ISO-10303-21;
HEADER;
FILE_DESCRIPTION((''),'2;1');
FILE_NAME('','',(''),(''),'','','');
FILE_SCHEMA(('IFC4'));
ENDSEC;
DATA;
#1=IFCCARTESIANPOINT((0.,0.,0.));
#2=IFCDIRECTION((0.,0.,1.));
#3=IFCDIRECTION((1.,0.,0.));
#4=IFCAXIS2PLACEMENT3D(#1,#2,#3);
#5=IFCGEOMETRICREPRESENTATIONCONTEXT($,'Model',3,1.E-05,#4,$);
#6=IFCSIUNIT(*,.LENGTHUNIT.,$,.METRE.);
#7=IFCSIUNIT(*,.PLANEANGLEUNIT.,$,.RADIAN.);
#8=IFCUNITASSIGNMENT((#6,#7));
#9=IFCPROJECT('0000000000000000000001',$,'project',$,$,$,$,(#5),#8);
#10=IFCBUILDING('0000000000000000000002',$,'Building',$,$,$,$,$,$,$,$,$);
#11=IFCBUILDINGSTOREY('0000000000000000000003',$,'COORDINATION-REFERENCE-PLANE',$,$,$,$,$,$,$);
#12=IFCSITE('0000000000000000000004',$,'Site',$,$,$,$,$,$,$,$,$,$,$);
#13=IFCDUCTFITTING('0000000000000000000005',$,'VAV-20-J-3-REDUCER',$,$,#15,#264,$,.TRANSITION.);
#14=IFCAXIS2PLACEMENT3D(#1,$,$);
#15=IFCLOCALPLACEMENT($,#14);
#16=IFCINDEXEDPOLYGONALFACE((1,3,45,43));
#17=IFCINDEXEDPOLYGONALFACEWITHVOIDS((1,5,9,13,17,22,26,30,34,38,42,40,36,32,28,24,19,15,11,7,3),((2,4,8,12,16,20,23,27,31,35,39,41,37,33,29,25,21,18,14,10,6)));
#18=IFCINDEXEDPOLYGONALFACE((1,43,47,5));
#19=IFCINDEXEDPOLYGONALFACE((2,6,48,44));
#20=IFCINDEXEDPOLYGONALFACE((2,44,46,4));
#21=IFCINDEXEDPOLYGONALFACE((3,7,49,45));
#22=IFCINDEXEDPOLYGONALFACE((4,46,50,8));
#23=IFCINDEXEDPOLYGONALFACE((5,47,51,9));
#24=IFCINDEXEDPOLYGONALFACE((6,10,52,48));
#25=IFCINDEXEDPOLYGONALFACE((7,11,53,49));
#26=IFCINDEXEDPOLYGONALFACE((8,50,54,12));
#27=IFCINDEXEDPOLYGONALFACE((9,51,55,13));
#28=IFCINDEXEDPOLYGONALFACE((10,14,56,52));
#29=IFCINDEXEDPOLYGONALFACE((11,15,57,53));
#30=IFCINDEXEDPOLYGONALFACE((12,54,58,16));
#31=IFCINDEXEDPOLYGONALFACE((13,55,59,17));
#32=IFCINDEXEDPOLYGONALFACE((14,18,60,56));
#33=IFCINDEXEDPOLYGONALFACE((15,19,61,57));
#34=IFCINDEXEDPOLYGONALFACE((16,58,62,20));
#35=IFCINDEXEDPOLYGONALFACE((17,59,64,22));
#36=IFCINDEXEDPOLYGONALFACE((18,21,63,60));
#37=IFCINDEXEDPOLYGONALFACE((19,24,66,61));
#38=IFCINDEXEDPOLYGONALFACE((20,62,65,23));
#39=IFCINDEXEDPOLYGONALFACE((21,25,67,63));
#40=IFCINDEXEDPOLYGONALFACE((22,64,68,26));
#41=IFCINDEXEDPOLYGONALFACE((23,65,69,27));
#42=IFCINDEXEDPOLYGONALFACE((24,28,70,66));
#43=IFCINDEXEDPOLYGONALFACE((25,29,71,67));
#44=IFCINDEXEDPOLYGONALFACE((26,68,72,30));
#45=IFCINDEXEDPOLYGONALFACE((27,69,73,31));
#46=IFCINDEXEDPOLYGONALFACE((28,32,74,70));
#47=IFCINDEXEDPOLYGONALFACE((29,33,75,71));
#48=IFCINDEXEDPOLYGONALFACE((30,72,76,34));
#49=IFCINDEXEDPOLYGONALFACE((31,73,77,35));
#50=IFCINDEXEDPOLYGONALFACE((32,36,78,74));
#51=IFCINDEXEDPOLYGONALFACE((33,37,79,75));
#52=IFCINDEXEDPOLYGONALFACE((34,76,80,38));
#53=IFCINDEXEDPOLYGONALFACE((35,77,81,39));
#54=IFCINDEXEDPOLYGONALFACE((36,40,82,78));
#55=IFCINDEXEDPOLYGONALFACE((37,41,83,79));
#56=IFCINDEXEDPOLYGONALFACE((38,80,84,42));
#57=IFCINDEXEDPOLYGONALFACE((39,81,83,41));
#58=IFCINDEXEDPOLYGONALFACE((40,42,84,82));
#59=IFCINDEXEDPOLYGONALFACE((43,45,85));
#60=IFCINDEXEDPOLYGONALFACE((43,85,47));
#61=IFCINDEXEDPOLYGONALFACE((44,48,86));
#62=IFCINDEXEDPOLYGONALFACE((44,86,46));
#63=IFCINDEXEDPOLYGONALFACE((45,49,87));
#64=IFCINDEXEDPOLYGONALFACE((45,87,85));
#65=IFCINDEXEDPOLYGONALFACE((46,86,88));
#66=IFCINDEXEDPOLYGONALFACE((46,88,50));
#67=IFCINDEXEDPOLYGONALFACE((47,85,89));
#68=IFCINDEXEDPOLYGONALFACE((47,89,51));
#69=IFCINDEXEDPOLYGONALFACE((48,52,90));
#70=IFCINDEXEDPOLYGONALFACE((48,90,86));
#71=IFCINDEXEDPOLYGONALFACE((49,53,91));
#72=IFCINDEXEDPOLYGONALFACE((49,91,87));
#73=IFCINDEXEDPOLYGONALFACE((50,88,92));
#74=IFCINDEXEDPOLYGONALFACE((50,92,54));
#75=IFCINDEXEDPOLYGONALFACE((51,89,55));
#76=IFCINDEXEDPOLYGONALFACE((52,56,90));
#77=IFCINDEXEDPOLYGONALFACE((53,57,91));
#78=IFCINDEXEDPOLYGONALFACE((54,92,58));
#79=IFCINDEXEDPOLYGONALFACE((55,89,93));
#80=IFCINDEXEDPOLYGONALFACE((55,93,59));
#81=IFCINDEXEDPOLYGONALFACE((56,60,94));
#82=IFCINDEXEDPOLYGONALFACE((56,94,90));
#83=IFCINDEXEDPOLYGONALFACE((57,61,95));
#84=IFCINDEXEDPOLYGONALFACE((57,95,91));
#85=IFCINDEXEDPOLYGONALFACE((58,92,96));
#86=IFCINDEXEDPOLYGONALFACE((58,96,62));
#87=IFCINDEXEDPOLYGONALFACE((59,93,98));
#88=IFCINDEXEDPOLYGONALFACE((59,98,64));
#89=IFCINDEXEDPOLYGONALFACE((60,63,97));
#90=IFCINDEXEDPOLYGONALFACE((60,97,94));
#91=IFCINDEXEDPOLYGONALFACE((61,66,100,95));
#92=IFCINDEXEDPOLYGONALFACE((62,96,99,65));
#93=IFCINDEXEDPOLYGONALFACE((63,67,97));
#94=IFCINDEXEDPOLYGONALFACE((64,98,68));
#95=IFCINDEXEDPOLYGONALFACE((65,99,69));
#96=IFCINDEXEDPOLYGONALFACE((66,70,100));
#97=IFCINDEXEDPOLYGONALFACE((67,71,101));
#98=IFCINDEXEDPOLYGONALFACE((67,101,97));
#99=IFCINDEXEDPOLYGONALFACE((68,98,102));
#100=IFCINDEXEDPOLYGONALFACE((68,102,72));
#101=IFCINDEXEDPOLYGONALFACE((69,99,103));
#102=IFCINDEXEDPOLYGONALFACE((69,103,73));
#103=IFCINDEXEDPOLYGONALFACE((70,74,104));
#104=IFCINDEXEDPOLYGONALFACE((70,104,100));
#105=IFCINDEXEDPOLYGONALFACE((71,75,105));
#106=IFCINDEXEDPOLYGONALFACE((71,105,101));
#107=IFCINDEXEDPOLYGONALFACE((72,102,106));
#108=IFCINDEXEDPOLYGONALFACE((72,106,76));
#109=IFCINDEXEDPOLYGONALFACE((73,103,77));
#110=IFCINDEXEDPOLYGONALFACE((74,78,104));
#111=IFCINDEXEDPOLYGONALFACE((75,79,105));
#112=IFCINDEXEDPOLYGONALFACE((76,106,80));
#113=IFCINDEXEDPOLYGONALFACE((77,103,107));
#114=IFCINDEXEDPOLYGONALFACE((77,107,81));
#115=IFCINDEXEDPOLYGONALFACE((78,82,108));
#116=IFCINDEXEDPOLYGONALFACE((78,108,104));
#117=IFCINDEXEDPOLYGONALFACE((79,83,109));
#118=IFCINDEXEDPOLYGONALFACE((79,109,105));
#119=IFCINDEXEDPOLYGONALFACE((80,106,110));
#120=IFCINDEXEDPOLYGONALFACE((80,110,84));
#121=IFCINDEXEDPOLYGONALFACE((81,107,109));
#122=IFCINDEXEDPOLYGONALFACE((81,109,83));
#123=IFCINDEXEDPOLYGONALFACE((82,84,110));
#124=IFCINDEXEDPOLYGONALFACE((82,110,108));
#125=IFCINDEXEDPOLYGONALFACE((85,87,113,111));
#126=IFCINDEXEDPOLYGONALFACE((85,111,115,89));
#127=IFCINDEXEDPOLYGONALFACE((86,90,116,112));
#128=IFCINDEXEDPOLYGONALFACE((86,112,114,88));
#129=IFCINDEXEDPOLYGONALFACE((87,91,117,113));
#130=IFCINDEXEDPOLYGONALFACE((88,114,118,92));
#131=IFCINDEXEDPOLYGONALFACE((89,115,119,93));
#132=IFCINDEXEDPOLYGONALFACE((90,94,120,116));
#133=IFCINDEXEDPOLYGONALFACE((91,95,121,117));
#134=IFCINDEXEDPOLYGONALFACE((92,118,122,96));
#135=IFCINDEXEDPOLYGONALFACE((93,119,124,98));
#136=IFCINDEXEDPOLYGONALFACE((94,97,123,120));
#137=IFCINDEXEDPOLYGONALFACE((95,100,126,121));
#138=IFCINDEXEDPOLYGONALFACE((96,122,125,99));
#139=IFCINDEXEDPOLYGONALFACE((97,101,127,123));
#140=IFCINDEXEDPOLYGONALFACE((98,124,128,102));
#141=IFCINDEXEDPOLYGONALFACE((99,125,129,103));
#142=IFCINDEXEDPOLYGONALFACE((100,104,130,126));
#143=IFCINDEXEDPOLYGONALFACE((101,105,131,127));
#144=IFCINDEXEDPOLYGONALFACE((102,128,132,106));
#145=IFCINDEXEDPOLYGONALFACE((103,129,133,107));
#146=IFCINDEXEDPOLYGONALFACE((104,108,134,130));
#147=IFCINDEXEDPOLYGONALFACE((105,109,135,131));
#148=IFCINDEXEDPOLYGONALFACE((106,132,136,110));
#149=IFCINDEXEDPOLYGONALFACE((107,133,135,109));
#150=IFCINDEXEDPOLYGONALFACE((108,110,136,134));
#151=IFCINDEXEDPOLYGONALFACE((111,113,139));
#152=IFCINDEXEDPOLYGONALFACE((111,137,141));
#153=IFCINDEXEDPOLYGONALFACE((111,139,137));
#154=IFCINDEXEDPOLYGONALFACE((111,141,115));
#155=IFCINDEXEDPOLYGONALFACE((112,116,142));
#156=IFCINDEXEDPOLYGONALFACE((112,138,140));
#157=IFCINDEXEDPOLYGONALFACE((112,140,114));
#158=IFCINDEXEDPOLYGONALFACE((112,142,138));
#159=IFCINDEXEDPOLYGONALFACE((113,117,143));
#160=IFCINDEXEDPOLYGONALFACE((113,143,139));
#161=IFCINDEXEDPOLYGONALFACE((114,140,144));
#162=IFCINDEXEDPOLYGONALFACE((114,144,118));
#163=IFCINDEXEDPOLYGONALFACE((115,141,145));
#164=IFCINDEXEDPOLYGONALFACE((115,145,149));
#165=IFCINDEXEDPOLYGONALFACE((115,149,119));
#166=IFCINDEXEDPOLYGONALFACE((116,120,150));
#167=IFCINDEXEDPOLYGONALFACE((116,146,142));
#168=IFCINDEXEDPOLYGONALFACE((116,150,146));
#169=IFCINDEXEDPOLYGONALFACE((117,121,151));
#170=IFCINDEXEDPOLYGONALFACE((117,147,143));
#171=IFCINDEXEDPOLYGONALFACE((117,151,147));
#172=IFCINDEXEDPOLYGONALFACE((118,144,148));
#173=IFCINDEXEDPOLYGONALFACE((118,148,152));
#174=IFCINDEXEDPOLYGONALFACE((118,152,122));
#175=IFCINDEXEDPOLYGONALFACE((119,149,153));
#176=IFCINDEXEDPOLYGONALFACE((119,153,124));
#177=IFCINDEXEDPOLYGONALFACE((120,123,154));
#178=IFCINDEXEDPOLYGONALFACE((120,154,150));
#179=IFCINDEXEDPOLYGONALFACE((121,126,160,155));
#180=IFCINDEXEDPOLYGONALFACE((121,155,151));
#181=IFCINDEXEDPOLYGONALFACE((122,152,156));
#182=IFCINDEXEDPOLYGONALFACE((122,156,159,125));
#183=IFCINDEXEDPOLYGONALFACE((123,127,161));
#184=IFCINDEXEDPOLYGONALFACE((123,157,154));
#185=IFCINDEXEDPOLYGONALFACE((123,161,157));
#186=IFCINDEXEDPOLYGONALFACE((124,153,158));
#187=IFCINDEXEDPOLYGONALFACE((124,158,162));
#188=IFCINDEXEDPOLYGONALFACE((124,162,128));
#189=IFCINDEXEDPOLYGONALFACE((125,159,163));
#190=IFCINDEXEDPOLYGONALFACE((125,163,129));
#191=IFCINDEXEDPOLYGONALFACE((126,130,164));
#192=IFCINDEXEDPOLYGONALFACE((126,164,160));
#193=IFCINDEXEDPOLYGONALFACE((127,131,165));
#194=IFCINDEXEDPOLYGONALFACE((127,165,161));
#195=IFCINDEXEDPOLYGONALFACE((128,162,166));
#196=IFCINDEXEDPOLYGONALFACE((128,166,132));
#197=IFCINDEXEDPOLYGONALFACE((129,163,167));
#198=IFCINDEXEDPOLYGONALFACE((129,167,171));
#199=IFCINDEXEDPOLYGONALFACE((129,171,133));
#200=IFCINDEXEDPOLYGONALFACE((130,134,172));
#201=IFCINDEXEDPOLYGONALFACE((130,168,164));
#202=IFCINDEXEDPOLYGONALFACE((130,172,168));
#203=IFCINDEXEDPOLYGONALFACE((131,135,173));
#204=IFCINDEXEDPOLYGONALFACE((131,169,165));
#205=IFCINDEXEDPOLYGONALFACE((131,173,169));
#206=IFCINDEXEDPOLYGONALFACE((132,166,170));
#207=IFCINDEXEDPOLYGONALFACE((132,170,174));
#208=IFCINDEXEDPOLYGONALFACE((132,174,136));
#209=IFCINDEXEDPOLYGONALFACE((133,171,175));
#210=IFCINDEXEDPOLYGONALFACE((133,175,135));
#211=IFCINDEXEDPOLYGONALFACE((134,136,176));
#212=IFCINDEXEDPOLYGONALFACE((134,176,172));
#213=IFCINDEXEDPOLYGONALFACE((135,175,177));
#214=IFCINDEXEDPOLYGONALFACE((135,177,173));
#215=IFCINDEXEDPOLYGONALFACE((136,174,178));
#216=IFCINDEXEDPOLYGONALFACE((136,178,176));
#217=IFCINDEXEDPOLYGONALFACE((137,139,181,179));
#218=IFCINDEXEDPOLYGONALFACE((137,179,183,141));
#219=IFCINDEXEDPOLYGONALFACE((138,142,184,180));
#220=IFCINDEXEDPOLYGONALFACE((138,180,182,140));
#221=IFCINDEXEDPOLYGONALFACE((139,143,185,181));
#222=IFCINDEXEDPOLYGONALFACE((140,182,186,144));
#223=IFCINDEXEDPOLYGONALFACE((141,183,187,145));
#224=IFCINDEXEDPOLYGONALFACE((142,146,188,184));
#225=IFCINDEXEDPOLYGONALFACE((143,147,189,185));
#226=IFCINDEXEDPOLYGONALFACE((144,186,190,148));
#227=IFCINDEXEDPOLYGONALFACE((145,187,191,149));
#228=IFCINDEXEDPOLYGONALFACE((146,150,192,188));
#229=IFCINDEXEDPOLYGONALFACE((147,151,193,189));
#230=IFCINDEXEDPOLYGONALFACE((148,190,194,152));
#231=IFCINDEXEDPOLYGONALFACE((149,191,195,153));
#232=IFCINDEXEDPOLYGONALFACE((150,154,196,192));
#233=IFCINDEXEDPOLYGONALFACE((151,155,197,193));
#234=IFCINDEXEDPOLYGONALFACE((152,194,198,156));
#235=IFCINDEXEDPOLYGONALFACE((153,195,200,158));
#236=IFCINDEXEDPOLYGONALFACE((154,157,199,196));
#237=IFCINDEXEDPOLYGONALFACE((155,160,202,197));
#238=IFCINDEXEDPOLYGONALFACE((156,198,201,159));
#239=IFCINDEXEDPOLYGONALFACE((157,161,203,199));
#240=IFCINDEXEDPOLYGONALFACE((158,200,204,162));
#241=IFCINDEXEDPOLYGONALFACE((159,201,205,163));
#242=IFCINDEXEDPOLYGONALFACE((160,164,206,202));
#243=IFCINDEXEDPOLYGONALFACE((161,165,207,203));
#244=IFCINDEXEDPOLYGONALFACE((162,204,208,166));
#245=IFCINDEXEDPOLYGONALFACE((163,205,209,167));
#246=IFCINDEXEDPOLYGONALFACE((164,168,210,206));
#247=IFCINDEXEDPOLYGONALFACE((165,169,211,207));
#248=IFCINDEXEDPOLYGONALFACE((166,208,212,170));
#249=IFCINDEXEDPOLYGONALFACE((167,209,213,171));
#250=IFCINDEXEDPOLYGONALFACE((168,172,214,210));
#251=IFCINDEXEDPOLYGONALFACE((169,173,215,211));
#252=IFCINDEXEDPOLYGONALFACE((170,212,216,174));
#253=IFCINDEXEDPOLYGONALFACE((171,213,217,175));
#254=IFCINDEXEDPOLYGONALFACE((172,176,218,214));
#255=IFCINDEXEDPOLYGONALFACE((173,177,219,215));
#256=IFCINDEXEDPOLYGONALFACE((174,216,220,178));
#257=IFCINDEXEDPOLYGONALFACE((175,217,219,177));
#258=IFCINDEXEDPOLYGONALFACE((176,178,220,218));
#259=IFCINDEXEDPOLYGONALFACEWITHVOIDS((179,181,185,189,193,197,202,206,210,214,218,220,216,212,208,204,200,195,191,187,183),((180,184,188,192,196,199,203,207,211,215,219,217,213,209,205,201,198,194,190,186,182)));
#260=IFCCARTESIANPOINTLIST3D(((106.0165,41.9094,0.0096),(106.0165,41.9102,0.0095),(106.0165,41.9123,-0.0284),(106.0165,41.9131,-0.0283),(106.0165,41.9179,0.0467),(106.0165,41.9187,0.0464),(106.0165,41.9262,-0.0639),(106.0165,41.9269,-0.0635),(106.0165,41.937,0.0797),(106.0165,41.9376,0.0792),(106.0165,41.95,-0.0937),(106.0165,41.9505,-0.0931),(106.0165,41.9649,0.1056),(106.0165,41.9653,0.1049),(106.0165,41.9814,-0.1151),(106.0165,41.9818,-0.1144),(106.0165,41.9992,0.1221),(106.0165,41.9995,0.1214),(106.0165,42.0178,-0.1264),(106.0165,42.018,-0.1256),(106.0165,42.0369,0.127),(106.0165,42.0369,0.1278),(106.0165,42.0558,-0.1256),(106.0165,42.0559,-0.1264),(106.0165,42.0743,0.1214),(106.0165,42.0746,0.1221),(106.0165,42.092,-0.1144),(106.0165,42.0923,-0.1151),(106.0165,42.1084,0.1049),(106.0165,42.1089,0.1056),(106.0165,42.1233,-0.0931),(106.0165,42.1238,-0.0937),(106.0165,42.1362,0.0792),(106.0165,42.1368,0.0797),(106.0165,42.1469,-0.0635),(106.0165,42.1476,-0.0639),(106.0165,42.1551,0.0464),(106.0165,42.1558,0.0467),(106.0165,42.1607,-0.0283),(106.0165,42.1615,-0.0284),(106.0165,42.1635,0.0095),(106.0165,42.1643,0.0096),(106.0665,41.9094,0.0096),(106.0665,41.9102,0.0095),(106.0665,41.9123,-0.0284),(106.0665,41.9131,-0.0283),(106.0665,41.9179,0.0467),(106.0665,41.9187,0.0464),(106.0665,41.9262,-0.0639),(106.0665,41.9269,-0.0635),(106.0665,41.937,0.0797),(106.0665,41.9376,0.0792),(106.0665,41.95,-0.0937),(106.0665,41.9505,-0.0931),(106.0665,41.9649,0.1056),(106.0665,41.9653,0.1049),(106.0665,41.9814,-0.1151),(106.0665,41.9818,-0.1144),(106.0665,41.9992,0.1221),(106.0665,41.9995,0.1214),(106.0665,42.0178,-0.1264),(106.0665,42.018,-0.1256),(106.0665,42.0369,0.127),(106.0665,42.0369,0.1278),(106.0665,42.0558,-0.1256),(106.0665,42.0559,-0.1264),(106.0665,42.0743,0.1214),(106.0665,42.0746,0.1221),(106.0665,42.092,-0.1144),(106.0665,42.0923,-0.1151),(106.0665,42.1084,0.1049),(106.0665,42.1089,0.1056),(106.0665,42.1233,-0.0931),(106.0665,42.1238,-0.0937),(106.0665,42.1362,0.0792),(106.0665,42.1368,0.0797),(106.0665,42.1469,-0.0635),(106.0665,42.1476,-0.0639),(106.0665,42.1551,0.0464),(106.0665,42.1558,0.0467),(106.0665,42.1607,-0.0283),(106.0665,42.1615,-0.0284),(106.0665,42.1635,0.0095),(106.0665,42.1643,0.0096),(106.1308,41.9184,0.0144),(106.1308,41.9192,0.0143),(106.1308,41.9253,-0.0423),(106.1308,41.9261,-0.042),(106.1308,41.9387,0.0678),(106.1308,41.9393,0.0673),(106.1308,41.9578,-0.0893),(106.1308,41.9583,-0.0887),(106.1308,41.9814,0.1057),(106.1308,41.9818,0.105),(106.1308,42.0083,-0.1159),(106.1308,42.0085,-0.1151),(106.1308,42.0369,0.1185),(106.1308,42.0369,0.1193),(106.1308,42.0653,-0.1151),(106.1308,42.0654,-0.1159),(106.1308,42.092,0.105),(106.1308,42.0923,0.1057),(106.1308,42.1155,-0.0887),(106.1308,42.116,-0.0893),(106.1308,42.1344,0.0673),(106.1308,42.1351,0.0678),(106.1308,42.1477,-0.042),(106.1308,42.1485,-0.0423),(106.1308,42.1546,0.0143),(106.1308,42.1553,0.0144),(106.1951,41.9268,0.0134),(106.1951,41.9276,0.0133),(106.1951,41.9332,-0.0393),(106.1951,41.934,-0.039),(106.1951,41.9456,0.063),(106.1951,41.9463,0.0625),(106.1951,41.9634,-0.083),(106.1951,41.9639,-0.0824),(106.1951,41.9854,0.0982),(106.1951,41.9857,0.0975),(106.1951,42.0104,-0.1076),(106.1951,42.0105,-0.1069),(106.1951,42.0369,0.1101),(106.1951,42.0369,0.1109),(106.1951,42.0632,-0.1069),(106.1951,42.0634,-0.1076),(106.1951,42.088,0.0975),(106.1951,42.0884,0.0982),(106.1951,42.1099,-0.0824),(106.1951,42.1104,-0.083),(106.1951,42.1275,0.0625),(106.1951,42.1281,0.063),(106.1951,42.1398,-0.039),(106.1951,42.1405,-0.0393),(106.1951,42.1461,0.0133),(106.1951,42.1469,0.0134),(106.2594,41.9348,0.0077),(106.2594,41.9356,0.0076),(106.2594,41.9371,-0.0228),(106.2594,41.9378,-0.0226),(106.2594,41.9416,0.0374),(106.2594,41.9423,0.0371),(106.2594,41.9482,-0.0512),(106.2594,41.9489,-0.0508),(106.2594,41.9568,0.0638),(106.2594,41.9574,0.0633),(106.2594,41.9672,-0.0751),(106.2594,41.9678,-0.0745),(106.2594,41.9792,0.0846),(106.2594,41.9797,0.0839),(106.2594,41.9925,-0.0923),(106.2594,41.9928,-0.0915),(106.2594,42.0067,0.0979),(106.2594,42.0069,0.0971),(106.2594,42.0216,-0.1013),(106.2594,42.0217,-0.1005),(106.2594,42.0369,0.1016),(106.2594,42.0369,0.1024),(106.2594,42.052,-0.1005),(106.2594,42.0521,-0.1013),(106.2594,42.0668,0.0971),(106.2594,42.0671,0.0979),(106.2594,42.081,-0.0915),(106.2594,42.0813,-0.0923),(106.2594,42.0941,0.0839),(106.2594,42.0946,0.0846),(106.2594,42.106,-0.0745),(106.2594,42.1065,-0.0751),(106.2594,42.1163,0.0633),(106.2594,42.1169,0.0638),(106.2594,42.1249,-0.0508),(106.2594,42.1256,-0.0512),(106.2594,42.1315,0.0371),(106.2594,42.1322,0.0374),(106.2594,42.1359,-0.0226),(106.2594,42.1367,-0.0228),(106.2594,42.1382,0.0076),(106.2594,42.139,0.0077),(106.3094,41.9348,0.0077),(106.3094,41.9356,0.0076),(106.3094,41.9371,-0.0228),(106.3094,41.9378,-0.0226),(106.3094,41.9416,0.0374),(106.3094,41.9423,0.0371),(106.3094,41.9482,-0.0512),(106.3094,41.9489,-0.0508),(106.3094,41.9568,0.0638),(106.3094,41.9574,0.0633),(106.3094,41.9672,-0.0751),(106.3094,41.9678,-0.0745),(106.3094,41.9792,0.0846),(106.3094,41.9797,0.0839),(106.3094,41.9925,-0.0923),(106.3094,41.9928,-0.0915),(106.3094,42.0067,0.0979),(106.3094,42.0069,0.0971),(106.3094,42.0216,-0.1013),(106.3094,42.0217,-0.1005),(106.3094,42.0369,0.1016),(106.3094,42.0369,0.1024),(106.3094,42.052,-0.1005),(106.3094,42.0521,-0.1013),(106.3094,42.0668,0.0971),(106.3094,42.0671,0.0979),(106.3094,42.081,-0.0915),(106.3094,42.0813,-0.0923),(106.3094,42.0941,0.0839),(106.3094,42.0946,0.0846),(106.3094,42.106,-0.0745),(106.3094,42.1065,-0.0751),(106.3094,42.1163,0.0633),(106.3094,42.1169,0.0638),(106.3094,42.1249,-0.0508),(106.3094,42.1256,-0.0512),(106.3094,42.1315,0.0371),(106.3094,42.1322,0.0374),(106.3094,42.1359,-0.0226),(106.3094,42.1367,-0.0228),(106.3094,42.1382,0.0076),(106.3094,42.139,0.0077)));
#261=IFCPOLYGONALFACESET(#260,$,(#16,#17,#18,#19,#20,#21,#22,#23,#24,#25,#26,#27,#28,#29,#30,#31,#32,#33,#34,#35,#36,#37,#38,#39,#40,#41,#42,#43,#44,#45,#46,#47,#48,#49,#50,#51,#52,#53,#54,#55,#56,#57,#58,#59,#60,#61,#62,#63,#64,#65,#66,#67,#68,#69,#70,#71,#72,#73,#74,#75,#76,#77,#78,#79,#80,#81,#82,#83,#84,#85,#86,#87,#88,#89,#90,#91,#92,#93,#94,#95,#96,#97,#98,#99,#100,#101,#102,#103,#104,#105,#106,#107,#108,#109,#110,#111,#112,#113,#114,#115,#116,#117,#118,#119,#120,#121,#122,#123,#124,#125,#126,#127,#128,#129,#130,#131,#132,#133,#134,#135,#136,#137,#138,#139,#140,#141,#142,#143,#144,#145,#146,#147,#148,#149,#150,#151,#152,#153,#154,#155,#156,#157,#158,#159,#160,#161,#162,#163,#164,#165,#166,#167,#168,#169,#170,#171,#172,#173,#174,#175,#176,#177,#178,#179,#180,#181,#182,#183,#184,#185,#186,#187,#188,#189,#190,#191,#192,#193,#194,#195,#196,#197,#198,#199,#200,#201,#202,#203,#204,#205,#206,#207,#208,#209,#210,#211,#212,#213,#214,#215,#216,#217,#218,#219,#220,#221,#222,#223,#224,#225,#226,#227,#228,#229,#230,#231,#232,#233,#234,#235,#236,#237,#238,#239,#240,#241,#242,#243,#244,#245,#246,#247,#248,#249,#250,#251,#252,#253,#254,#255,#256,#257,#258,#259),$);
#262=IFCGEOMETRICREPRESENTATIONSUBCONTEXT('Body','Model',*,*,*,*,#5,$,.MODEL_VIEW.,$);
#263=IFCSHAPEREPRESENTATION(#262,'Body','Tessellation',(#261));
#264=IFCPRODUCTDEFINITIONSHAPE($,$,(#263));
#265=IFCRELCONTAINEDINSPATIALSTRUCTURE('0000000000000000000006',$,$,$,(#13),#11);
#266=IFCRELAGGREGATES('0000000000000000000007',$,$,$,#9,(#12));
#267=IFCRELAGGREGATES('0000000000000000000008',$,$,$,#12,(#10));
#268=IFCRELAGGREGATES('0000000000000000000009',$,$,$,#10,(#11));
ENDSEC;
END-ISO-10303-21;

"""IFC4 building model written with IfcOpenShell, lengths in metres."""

from ifc_helpers import new_model, entity, si_unit, frame, origin_with_axes, place, context, subcontext, project, spatial, element, save


model = new_model("IFC4")

# Units and contexts
model_context_1 = context("Model", 3, precision=1e-05, world=origin_with_axes())
body_context_1 = subcontext(model_context_1, "Body", "Model", "MODEL_VIEW")
ifc_project = project(units=[si_unit("LENGTHUNIT", "METRE"), si_unit("PLANEANGLEUNIT", "RADIAN")], contexts=[model_context_1])

# Site, building, storey
site = spatial("IfcSite", under=ifc_project, Name="Site")
building = spatial("IfcBuilding", under=site, Name="Building")
storey = spatial("IfcBuildingStorey", under=building, Name="COORDINATION-REFERENCE-PLANE")

# Duct fitting
for number, where, z_axis, x_axis, name in (
    (1, (106.0165, 42.0369, 0.0), (0.0, 1.0, 0.0), (0.0, 0.0, 1.0), "VAV-20-J-3-REDUCER"),
):
    element("IfcDuctFitting", number, at=place(None, frame(where, z_axis=z_axis, x_axis=x_axis)), inside=storey, Name=name, PredefinedType="TRANSITION", context=body_context_1, shape_type="SweptSolid", body=[
        entity("IfcRevolvedAreaSolid", entity("IfcArbitraryClosedProfileDef", "AREA", None, entity("IfcPolyline", [entity("IfcCartesianPoint", [0.1278, 0.0]), entity("IfcCartesianPoint", [0.1278, 0.05]), entity("IfcCartesianPoint", [0.1024, 0.2429]), entity("IfcCartesianPoint", [0.1024, 0.2929]), entity("IfcCartesianPoint", [0.1016, 0.2929]), entity("IfcCartesianPoint", [0.1016, 0.2429]), entity("IfcCartesianPoint", [0.127, 0.05]), entity("IfcCartesianPoint", [0.127, 0.0]), entity("IfcCartesianPoint", [0.1278, 0.0])])), entity("IfcAxis2Placement3D", entity("IfcCartesianPoint", [0.0, 0.0, 0.0])), entity("IfcAxis1Placement", entity("IfcCartesianPoint", [0.0, 0.0, 0.0]), entity("IfcDirection", [0.0, 1.0, 0.0])), 6.283185),
    ])

save(model, "model.ifc")
